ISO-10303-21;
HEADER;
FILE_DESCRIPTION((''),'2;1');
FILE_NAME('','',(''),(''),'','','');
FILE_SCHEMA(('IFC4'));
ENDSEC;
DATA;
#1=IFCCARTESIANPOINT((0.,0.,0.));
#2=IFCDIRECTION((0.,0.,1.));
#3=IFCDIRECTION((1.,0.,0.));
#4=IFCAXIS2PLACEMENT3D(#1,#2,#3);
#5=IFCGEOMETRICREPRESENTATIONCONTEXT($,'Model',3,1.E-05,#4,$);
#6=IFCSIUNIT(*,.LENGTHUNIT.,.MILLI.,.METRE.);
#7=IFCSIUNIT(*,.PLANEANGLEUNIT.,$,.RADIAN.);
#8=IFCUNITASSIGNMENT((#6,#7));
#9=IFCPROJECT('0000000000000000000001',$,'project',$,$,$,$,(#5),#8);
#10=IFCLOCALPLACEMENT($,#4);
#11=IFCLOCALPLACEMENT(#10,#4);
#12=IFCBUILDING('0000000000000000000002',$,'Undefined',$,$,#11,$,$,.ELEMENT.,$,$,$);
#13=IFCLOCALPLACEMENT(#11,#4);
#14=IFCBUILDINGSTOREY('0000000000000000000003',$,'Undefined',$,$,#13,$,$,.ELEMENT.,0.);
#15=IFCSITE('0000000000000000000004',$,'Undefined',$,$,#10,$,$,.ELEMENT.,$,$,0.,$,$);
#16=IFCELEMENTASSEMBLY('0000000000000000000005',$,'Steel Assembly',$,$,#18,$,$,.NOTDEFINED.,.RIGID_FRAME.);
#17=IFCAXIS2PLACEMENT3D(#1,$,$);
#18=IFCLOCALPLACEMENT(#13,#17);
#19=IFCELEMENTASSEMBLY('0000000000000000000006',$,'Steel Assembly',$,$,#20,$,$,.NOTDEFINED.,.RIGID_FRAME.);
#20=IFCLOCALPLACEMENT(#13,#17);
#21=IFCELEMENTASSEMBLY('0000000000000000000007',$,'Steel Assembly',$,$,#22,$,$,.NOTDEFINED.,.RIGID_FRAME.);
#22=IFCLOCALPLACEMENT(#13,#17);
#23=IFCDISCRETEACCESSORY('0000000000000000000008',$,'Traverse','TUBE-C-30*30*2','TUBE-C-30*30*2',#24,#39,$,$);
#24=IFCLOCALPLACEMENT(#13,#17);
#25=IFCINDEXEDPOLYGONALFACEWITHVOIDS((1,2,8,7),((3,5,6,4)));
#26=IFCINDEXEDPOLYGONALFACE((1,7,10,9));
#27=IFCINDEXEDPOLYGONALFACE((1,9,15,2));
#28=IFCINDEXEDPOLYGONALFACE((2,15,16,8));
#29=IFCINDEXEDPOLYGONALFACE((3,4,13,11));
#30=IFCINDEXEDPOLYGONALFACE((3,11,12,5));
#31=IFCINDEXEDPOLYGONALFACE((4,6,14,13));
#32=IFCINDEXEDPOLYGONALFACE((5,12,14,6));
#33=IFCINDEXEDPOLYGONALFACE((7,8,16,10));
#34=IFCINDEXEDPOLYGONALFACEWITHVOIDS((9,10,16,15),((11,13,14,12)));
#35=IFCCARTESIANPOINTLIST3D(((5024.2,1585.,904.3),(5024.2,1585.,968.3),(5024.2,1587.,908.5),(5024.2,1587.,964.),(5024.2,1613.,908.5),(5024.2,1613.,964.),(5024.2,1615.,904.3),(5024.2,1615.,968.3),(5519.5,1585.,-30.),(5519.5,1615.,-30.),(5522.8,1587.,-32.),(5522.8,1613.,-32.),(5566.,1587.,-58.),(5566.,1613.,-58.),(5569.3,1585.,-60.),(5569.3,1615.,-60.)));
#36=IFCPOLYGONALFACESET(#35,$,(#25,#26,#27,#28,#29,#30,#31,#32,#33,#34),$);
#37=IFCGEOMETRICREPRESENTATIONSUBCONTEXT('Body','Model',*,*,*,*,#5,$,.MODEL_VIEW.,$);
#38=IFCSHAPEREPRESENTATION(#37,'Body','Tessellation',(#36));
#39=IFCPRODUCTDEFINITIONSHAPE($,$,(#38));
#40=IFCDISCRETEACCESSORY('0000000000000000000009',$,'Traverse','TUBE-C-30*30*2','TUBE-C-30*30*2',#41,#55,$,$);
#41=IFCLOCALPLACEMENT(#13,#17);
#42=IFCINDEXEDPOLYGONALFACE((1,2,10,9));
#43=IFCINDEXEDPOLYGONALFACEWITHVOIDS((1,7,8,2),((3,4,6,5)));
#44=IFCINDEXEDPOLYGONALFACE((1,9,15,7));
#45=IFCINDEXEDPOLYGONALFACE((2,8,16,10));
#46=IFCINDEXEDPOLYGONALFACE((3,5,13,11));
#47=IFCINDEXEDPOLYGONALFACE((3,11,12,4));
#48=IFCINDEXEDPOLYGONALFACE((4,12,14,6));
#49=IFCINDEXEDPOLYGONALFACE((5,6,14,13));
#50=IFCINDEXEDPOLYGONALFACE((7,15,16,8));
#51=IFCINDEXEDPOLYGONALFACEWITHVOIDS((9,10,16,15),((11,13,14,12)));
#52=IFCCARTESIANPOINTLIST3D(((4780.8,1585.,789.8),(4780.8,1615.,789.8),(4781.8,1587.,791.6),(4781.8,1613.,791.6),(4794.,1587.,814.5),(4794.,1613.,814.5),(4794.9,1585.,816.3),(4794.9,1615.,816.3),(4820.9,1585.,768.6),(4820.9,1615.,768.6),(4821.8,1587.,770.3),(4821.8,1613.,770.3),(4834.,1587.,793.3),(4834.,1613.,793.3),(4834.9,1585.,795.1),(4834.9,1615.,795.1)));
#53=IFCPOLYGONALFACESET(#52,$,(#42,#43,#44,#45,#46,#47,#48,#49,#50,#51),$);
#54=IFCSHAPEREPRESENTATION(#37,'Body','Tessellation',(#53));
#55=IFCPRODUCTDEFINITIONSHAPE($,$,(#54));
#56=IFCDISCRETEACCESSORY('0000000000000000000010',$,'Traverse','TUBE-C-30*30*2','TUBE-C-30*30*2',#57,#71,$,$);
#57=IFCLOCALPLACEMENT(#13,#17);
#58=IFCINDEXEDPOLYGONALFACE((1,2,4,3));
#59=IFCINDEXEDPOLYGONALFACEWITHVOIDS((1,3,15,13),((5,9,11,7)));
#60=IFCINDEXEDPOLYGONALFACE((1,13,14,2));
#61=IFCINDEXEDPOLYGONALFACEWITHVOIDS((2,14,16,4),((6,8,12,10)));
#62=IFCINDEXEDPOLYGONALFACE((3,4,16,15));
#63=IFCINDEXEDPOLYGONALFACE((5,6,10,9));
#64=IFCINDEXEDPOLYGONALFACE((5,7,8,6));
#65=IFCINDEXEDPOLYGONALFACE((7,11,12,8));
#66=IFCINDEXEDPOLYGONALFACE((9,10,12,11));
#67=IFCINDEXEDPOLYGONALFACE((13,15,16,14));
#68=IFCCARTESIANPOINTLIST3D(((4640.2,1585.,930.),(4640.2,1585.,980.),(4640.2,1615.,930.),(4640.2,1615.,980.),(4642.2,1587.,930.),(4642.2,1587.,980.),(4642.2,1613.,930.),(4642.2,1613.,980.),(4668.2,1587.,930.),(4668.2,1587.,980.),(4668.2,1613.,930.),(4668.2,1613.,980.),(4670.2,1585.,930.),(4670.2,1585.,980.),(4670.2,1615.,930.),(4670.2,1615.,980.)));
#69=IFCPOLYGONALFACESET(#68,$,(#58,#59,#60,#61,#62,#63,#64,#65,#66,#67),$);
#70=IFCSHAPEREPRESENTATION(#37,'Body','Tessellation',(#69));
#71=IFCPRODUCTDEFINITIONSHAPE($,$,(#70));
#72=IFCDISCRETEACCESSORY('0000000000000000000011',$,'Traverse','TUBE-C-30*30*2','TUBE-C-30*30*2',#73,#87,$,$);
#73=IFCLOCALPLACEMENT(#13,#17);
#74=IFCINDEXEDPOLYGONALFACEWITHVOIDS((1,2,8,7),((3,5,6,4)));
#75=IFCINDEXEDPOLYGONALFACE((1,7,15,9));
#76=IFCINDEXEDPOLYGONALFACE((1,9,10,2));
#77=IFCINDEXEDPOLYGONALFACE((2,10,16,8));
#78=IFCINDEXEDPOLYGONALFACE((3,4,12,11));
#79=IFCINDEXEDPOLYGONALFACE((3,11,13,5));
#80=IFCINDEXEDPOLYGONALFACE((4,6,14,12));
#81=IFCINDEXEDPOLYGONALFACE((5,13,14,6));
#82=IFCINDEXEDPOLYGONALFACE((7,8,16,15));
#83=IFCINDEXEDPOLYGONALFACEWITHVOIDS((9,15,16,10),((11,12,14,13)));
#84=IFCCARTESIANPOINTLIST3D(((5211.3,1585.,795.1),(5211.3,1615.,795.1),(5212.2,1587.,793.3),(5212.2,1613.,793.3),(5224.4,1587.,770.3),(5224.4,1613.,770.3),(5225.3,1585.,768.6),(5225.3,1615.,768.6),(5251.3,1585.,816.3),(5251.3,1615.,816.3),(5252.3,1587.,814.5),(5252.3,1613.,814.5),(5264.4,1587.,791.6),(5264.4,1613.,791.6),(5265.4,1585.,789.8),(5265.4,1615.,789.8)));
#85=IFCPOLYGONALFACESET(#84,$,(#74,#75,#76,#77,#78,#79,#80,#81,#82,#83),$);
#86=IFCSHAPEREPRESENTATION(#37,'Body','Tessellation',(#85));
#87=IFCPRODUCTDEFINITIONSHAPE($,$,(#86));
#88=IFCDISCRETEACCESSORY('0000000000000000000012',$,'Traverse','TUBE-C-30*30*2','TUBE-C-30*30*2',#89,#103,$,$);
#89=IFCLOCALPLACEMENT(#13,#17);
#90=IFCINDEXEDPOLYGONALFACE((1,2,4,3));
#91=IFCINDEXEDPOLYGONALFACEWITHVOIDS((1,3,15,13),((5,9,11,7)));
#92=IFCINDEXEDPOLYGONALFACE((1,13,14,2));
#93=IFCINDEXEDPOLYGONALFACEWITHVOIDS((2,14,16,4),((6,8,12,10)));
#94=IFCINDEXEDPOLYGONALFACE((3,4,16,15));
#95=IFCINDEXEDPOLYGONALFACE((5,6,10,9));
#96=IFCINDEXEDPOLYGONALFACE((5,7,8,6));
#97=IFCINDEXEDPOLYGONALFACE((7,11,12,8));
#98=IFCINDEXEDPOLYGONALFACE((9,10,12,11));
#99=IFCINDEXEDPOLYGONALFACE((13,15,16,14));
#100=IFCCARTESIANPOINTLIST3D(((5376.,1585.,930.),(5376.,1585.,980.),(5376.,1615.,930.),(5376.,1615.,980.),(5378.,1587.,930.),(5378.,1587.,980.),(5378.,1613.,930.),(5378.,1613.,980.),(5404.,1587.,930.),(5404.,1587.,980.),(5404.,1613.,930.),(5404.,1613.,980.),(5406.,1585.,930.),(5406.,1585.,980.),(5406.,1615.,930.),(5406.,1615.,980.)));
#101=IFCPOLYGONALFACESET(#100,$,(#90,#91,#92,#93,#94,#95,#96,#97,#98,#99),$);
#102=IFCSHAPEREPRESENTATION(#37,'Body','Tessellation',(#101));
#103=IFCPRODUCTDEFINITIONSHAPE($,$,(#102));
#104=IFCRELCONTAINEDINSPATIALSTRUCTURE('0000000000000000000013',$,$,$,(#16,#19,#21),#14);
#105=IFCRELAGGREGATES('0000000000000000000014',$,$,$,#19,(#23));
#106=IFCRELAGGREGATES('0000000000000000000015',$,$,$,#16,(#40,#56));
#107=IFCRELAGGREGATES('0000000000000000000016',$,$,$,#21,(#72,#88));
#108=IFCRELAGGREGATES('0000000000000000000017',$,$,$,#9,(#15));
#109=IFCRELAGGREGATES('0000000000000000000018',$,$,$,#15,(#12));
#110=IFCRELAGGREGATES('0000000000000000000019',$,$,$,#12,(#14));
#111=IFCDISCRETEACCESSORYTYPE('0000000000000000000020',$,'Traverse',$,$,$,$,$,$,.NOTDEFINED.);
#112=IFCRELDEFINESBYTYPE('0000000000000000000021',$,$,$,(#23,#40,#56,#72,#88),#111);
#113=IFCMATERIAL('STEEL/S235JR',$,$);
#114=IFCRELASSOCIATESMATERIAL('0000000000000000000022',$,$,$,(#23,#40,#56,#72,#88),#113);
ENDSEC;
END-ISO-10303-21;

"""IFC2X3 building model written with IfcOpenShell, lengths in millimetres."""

from ifc_helpers import new_model, si_unit, frame, origin_with_axes, origin_2d_with_axis, place, context, subcontext, project, spatial, hollow_rectangle, extrude, clip, halfspace, material, type_object, element, aggregate, save


model = new_model("IFC2X3")

# Units and contexts
model_context = context("Model", 3, precision=1e-05, world=origin_with_axes())
body_context = subcontext(model_context, "Body", "Model", "MODEL_VIEW")
ifc_project = project(units=[si_unit("LENGTHUNIT", "METRE", prefix="MILLI"), si_unit("PLANEANGLEUNIT", "RADIAN")], contexts=[model_context])

# Site, building, storey
site_placement = place(None, origin_with_axes())
site = spatial("IfcSite", under=ifc_project, at=site_placement, Name="Undefined", CompositionType="ELEMENT", RefElevation=0.0)
building_placement = place(site_placement, origin_with_axes())
building = spatial("IfcBuilding", under=site, at=building_placement, Name="Undefined", CompositionType="ELEMENT")
storey_placement = place(building_placement, origin_with_axes())
storey = spatial("IfcBuildingStorey", under=building, at=storey_placement, Name="Undefined", CompositionType="ELEMENT", Elevation=0.0)

# Element assembly
assembly_1_placement = place(storey_placement, origin_with_axes())
assembly_1 = element("IfcElementAssembly", 1, at=assembly_1_placement, inside=storey, Name="Steel Assembly", AssemblyPlace="NOTDEFINED", PredefinedType="RIGID_FRAME")
ifc_material = material(Name="STEEL/S235JR")

# Element assembly
assembly_2_placement = place(storey_placement, origin_with_axes())
assembly_2 = element("IfcElementAssembly", 2, at=assembly_2_placement, inside=storey, Name="Steel Assembly", AssemblyPlace="NOTDEFINED", PredefinedType="RIGID_FRAME")

# Element assembly
assembly_3_placement = place(storey_placement, origin_with_axes())
assembly_3 = element("IfcElementAssembly", 3, at=assembly_3_placement, inside=storey, Name="Steel Assembly", AssemblyPlace="NOTDEFINED", PredefinedType="RIGID_FRAME")

# Discrete accessories
discrete_accessory_type_1 = type_object("IfcDiscreteAccessoryType", Name="Traverse")
discrete_accessory_1_placement = place(assembly_2_placement, frame((4999.0, 1600.0, 983.8), z_axis=(-0.000011, 1.0, 0.0), x_axis=(0.46842, 0.000005, -0.883506)))
discrete_accessory_1 = element("IfcDiscreteAccessory", 4, at=discrete_accessory_1_placement, type_object=discrete_accessory_type_1, material=ifc_material, Name="Traverse", Description="TUBE-C-30*30*2", ObjectType="TUBE-C-30*30*2", context=body_context, shape_type="Clipping", body=[
    clip(clip(extrude(hollow_rectangle(XDim=30.0, YDim=30.0, WallThickness=2.0, at=origin_2d_with_axis()), frame((1218.2, 0.0, 0.0), z_axis=(-1.0, 0.0, 0.0), x_axis=(0.0, -1.0, 0.0)), (0.0, 0.0, 1.0), 1218.2), halfspace(frame((1139.5, 15.0, 0.0), z_axis=(-0.515548, -0.856861, -0.000003), x_axis=(0.000003, -0.000005, 1.0)), True)), halfspace(frame((82.1, 15.0, 0.0), z_axis=(-0.46842, 0.883506, 0.000005), x_axis=(0.000003, -0.000005, 1.0)), False)),
])
aggregate(assembly_2, [discrete_accessory_1])
discrete_accessory_2_placement = place(assembly_1_placement, frame((4787.9, 1600.0, 803.0), z_axis=(0.0, 1.0, 0.0), x_axis=(0.883506, 0.0, -0.46842)))
discrete_accessory_2 = element("IfcDiscreteAccessory", 5, at=discrete_accessory_2_placement, type_object=discrete_accessory_type_1, material=ifc_material, Name="Traverse", Description="TUBE-C-30*30*2", ObjectType="TUBE-C-30*30*2", context=body_context, shape_type="SweptSolid", body=[
    extrude(hollow_rectangle(XDim=30.0, YDim=30.0, WallThickness=2.0, at=origin_2d_with_axis()), frame((45.3, 0.0, 0.0), z_axis=(-1.0, 0.0, 0.0), x_axis=(0.0, -1.0, 0.0)), (0.0, 0.0, 1.0), 45.3),
])
discrete_accessory_3_placement = place(assembly_1_placement, frame((4655.2, 1600.0, 930.0), z_axis=(0.0, 0.0, 1.0), x_axis=(1.0, 0.0, 0.0)))
discrete_accessory_3 = element("IfcDiscreteAccessory", 6, at=discrete_accessory_3_placement, type_object=discrete_accessory_type_1, material=ifc_material, Name="Traverse", Description="TUBE-C-30*30*2", ObjectType="TUBE-C-30*30*2", context=body_context, shape_type="SweptSolid", body=[
    extrude(hollow_rectangle(XDim=30.0, YDim=30.0, WallThickness=2.0, at=origin_2d_with_axis()), frame((0.0, 0.0, 50.0), z_axis=(0.0, 0.0, -1.0), x_axis=(-1.0, 0.0, 0.0)), (0.0, 0.0, 1.0), 50.0),
])
aggregate(assembly_1, [discrete_accessory_2, discrete_accessory_3])
discrete_accessory_4_placement = place(assembly_3_placement, frame((5258.3, 1600.0, 803.0), z_axis=(0.0, 1.0, 0.0), x_axis=(-0.883506, 0.0, -0.46842)))
discrete_accessory_4 = element("IfcDiscreteAccessory", 7, at=discrete_accessory_4_placement, type_object=discrete_accessory_type_1, material=ifc_material, Name="Traverse", Description="TUBE-C-30*30*2", ObjectType="TUBE-C-30*30*2", context=body_context, shape_type="SweptSolid", body=[
    extrude(hollow_rectangle(XDim=30.0, YDim=30.0, WallThickness=2.0, at=origin_2d_with_axis()), frame((45.3, 0.0, 0.0), z_axis=(-1.0, 0.0, 0.0), x_axis=(0.0, -1.0, 0.0)), (0.0, 0.0, 1.0), 45.3),
])
discrete_accessory_5_placement = place(assembly_3_placement, frame((5391.0, 1600.0, 930.0), z_axis=(0.0, 0.0, 1.0), x_axis=(1.0, 0.0, 0.0)))
discrete_accessory_5 = element("IfcDiscreteAccessory", 8, at=discrete_accessory_5_placement, type_object=discrete_accessory_type_1, material=ifc_material, Name="Traverse", Description="TUBE-C-30*30*2", ObjectType="TUBE-C-30*30*2", context=body_context, shape_type="SweptSolid", body=[
    extrude(hollow_rectangle(XDim=30.0, YDim=30.0, WallThickness=2.0, at=origin_2d_with_axis()), frame((0.0, 0.0, 50.0), z_axis=(0.0, 0.0, -1.0), x_axis=(-1.0, 0.0, 0.0)), (0.0, 0.0, 1.0), 50.0),
])
aggregate(assembly_3, [discrete_accessory_4, discrete_accessory_5])

save(model, "model.ifc")
